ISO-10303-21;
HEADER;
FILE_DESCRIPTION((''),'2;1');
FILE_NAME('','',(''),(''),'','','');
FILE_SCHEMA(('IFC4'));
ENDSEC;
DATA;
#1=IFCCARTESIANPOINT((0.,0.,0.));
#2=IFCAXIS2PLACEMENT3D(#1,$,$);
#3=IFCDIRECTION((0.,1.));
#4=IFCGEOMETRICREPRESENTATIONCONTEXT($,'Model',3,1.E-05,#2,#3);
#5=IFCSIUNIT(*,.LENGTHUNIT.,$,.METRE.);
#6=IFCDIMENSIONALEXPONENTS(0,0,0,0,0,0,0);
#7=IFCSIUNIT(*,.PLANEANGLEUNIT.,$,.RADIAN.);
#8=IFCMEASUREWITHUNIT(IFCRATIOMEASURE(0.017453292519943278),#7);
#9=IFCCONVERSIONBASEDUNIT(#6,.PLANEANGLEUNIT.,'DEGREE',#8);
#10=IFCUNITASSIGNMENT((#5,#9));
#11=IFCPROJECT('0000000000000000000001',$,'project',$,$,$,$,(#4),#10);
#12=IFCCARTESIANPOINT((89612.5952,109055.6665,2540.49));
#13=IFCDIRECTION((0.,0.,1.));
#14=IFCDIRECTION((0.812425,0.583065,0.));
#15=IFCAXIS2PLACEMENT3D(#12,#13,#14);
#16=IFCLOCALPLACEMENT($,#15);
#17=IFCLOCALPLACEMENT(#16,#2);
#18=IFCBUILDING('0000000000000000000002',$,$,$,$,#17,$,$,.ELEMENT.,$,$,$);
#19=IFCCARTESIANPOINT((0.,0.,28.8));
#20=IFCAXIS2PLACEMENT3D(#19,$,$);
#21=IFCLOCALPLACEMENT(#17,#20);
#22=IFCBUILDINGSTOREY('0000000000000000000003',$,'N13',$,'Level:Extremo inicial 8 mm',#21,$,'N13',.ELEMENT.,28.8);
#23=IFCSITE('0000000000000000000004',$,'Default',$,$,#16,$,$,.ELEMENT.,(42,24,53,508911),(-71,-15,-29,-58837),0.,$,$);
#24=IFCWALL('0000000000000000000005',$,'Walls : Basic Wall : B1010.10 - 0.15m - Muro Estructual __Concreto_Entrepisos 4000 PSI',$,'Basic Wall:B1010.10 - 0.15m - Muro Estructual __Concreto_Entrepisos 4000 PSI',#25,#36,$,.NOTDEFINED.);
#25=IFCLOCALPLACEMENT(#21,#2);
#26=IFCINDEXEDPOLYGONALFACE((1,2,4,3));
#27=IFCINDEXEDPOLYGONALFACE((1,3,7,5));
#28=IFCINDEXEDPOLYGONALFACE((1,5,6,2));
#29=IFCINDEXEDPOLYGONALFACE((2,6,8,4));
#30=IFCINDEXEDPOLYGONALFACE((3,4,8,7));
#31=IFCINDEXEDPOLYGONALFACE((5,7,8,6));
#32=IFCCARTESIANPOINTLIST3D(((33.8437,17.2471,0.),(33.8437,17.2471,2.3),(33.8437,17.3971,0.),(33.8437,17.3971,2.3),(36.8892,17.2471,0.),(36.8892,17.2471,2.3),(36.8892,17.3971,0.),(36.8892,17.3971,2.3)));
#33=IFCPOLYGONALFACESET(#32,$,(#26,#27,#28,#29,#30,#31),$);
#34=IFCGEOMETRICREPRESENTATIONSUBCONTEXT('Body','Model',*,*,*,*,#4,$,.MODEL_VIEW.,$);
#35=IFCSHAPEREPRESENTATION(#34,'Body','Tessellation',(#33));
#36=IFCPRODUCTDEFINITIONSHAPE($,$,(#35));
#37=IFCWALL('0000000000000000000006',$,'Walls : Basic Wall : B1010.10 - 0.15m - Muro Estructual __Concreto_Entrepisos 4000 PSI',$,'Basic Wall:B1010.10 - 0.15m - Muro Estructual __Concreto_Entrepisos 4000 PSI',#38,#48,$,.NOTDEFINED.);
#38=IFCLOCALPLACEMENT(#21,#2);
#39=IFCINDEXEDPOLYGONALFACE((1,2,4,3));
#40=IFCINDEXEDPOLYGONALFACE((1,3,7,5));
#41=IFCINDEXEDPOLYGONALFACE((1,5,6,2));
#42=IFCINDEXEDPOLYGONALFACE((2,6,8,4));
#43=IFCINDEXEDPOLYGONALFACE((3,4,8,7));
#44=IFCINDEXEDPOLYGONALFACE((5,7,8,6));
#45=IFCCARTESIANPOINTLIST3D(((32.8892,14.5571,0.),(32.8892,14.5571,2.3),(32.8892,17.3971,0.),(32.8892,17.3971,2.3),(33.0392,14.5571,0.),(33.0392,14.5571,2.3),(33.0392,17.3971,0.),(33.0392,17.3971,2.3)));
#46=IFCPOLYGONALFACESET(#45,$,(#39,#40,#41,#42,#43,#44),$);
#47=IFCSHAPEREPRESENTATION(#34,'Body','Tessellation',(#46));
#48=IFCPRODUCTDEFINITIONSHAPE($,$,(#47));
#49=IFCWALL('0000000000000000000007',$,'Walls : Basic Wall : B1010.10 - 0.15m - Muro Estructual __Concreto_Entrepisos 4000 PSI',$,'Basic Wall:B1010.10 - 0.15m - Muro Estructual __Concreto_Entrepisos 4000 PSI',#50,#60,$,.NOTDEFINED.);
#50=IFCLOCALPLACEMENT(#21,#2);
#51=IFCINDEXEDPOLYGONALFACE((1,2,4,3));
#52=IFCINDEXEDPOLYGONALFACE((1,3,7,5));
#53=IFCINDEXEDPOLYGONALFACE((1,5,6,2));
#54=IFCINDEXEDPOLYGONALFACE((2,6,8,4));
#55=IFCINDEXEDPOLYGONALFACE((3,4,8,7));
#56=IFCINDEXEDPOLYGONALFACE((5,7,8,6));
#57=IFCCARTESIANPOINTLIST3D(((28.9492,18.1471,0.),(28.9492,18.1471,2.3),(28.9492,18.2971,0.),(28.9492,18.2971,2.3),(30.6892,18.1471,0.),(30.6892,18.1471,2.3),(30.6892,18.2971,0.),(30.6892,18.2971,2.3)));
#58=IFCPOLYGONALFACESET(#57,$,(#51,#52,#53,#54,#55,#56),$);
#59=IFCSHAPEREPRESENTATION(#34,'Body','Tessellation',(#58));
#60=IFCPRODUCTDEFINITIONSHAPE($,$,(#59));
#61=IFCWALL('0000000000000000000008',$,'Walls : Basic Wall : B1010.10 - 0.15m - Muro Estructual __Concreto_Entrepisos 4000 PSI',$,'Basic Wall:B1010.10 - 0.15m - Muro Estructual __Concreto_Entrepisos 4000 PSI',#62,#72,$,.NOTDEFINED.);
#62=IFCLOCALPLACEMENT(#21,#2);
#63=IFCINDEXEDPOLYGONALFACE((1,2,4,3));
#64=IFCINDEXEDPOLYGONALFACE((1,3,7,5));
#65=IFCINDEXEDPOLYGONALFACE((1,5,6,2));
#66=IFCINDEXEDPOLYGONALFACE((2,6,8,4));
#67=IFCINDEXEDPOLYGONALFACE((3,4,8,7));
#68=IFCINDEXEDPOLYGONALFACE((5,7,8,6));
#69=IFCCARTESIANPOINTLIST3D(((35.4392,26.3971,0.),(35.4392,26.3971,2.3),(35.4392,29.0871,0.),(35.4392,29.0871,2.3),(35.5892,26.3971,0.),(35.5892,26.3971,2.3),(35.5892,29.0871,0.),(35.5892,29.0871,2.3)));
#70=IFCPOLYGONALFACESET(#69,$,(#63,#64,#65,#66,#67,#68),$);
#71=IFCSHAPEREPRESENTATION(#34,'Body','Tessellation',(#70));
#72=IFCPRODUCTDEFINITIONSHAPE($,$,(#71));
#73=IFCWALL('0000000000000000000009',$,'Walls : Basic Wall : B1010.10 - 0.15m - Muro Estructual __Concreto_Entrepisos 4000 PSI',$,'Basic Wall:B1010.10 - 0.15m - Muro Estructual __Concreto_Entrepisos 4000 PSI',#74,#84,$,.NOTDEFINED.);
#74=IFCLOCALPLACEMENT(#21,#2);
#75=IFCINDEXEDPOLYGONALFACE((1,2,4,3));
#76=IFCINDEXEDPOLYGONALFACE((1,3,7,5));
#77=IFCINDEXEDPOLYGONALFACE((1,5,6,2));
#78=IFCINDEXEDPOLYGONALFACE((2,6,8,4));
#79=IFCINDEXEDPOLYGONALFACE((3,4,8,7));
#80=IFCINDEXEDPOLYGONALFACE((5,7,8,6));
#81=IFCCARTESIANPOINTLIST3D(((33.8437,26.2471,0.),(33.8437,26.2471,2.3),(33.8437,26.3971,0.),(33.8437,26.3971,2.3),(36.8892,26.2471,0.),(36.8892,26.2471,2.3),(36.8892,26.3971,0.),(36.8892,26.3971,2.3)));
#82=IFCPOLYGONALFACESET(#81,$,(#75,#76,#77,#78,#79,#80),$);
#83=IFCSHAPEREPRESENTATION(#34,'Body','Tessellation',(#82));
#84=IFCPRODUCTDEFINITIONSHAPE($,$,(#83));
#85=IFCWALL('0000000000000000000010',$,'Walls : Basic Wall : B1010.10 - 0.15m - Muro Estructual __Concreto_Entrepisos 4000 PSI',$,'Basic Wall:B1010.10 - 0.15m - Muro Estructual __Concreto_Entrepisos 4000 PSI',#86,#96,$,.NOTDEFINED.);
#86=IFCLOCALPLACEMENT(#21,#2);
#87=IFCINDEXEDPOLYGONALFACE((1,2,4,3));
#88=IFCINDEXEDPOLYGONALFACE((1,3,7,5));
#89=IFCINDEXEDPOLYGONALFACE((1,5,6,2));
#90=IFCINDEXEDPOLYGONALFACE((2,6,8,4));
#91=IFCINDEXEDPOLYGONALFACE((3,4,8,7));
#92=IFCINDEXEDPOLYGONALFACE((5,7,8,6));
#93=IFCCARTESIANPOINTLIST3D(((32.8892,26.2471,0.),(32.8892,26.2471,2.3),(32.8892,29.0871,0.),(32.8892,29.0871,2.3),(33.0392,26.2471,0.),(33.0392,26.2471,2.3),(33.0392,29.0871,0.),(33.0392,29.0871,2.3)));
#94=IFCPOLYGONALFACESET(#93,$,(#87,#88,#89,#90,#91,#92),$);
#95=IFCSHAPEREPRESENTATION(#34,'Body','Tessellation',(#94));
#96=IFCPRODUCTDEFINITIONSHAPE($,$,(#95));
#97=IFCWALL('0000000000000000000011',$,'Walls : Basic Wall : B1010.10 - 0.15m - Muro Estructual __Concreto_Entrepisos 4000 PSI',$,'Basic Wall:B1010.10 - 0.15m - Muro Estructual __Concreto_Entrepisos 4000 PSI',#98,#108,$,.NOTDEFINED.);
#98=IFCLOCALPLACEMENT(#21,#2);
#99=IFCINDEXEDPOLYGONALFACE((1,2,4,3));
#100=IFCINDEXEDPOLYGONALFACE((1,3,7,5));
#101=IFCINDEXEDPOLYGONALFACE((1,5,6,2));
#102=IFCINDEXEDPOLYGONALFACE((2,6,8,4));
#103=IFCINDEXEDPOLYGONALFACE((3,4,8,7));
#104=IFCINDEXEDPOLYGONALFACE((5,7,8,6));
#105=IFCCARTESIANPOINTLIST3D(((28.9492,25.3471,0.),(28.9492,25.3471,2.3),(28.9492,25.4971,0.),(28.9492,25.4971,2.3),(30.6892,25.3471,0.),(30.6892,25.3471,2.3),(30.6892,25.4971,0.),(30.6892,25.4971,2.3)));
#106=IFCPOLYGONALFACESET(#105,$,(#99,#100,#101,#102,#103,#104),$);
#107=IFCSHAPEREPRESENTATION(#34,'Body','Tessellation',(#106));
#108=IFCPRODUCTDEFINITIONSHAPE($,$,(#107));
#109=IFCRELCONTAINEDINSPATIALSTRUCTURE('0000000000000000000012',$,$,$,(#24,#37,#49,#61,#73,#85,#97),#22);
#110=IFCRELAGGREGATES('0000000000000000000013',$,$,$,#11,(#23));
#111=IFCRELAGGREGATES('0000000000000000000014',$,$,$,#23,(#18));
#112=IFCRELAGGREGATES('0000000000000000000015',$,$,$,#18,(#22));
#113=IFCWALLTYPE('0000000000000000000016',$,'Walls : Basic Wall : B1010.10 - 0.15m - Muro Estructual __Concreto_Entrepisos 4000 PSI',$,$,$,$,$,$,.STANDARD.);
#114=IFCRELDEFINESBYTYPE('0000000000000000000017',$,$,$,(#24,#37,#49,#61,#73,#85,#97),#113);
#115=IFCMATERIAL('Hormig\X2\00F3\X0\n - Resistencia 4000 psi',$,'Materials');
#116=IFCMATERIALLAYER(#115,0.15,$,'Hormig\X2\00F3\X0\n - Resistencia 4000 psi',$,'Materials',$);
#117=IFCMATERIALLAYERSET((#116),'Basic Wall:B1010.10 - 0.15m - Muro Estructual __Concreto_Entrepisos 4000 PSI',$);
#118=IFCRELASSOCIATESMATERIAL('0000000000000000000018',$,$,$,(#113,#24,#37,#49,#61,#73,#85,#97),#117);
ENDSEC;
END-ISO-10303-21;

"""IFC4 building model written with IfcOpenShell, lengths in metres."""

from ifc_helpers import new_model, entity, si_unit, converted_unit, direction, frame, frame_2d, origin, place, context, subcontext, project, spatial, rectangle, extrude, material, layer, layer_set, layer_usage, type_object, element, save


model = new_model("IFC4")

# Units and contexts
model_context = context("Model", 3, precision=1e-05, world=origin(), true_north=direction((0.0, 1.0)))
body_context = subcontext(model_context, "Body", "Model", "MODEL_VIEW")
ifc_project = project(units=[si_unit("LENGTHUNIT", "METRE"), converted_unit("PLANEANGLEUNIT", "DEGREE", entity("IfcRatioMeasure", 0.017453292519943278), si_unit("PLANEANGLEUNIT", "RADIAN"), dimensions=[0, 0, 0, 0, 0, 0, 0])], contexts=[model_context])

# Site, building, storey
site_placement = place(None, frame((89612.5952, 109055.6665, 2540.49), z_axis=(0.0, 0.0, 1.0), x_axis=(0.812425, 0.583065, 0.0)))
site = spatial("IfcSite", under=ifc_project, at=site_placement, Name="Default", CompositionType="ELEMENT", RefLatitude=(42, 24, 53, 508911), RefLongitude=(-71, -15, -29, -58837), RefElevation=0.0)
building_placement = place(site_placement, origin())
building = spatial("IfcBuilding", under=site, at=building_placement, CompositionType="ELEMENT")
storey_placement = place(building_placement, frame((0.0, 0.0, 28.8)))
storey = spatial("IfcBuildingStorey", under=building, at=storey_placement, Name="N13", ObjectType="Level:Extremo inicial 8 mm", LongName="N13", CompositionType="ELEMENT", Elevation=28.8)

# Walls
ifc_material = material(Name="Hormigón - Resistencia 4000 psi", Category="Materials")
ifc_layer_1 = layer(ifc_material, 0.15, Name="Hormigón - Resistencia 4000 psi", Category="Materials")
ifc_layer_set_1 = layer_set([ifc_layer_1], Name="Basic Wall:B1010.10 - 0.15m - Muro Estructual __Concreto_Entrepisos 4000 PSI")
wall_type_1 = type_object("IfcWallType", Name="Walls : Basic Wall : B1010.10 - 0.15m - Muro Estructual __Concreto_Entrepisos 4000 PSI", PredefinedType="STANDARD", material=ifc_layer_set_1)
ifc_layer_usage_1 = layer_usage(ifc_layer_set_1, "AXIS2", "NEGATIVE", 0.075)
wall_1_placement = place(storey_placement, frame((36.8892, 17.3221, 0.0), z_axis=(0.0, 0.0, 1.0), x_axis=(-1.0, 0.0, 0.0)))
element("IfcWall", 1, at=wall_1_placement, inside=storey, type_object=wall_type_1, material=ifc_layer_usage_1, Name="Walls : Basic Wall : B1010.10 - 0.15m - Muro Estructual __Concreto_Entrepisos 4000 PSI", ObjectType="Basic Wall:B1010.10 - 0.15m - Muro Estructual __Concreto_Entrepisos 4000 PSI", PredefinedType="NOTDEFINED", context=body_context, shape_type="SweptSolid", body=[
    extrude(rectangle(XDim=3.0455, YDim=0.15, at=frame_2d((1.5228, 0.0), x_axis=(-1.0, 0.0))), origin(), (0.0, 0.0, 1.0), 2.3),
])
ifc_layer_usage_2 = layer_usage(ifc_layer_set_1, "AXIS2", "NEGATIVE", 0.075)
wall_2_placement = place(storey_placement, frame((32.9642, 14.5571, 0.0), z_axis=(0.0, 0.0, 1.0), x_axis=(0.0, 1.0, 0.0)))
element("IfcWall", 2, at=wall_2_placement, inside=storey, type_object=wall_type_1, material=ifc_layer_usage_2, Name="Walls : Basic Wall : B1010.10 - 0.15m - Muro Estructual __Concreto_Entrepisos 4000 PSI", ObjectType="Basic Wall:B1010.10 - 0.15m - Muro Estructual __Concreto_Entrepisos 4000 PSI", PredefinedType="NOTDEFINED", context=body_context, shape_type="SweptSolid", body=[
    extrude(rectangle(XDim=2.84, YDim=0.15, at=frame_2d((1.42, 0.0), x_axis=(-1.0, 0.0))), origin(), (0.0, 0.0, 1.0), 2.3),
])
ifc_layer_usage_3 = layer_usage(ifc_layer_set_1, "AXIS2", "NEGATIVE", 0.075)
wall_3_placement = place(storey_placement, frame((30.6892, 18.2221, 0.0), z_axis=(0.0, 0.0, 1.0), x_axis=(-1.0, 0.0, 0.0)))
element("IfcWall", 3, at=wall_3_placement, inside=storey, type_object=wall_type_1, material=ifc_layer_usage_3, Name="Walls : Basic Wall : B1010.10 - 0.15m - Muro Estructual __Concreto_Entrepisos 4000 PSI", ObjectType="Basic Wall:B1010.10 - 0.15m - Muro Estructual __Concreto_Entrepisos 4000 PSI", PredefinedType="NOTDEFINED", context=body_context, shape_type="SweptSolid", body=[
    extrude(rectangle(XDim=1.74, YDim=0.15, at=frame_2d((0.87, 0.0), x_axis=(-1.0, 0.0))), origin(), (0.0, 0.0, 1.0), 2.3),
])
ifc_layer_usage_4 = layer_usage(ifc_layer_set_1, "AXIS2", "POSITIVE", -0.075)
wall_4_placement = place(storey_placement, frame((35.5142, 29.0871, 0.0), z_axis=(0.0, 0.0, 1.0), x_axis=(0.0, -1.0, 0.0)))
element("IfcWall", 4, at=wall_4_placement, inside=storey, type_object=wall_type_1, material=ifc_layer_usage_4, Name="Walls : Basic Wall : B1010.10 - 0.15m - Muro Estructual __Concreto_Entrepisos 4000 PSI", ObjectType="Basic Wall:B1010.10 - 0.15m - Muro Estructual __Concreto_Entrepisos 4000 PSI", PredefinedType="NOTDEFINED", context=body_context, shape_type="SweptSolid", body=[
    extrude(rectangle(XDim=2.69, YDim=0.15, at=frame_2d((1.345, 0.0), x_axis=(-1.0, 0.0))), origin(), (0.0, 0.0, 1.0), 2.3),
])
ifc_layer_usage_5 = layer_usage(ifc_layer_set_1, "AXIS2", "POSITIVE", -0.075)
wall_5_placement = place(storey_placement, frame((36.8892, 26.3221, 0.0), z_axis=(0.0, 0.0, 1.0), x_axis=(-1.0, 0.0, 0.0)))
element("IfcWall", 5, at=wall_5_placement, inside=storey, type_object=wall_type_1, material=ifc_layer_usage_5, Name="Walls : Basic Wall : B1010.10 - 0.15m - Muro Estructual __Concreto_Entrepisos 4000 PSI", ObjectType="Basic Wall:B1010.10 - 0.15m - Muro Estructual __Concreto_Entrepisos 4000 PSI", PredefinedType="NOTDEFINED", context=body_context, shape_type="SweptSolid", body=[
    extrude(rectangle(XDim=3.0455, YDim=0.15, at=frame_2d((1.5228, 0.0), x_axis=(-1.0, 0.0))), origin(), (0.0, 0.0, 1.0), 2.3),
])
ifc_layer_usage_6 = layer_usage(ifc_layer_set_1, "AXIS2", "POSITIVE", -0.075)
wall_6_placement = place(storey_placement, frame((32.9642, 29.0871, 0.0), z_axis=(0.0, 0.0, 1.0), x_axis=(0.0, -1.0, 0.0)))
element("IfcWall", 6, at=wall_6_placement, inside=storey, type_object=wall_type_1, material=ifc_layer_usage_6, Name="Walls : Basic Wall : B1010.10 - 0.15m - Muro Estructual __Concreto_Entrepisos 4000 PSI", ObjectType="Basic Wall:B1010.10 - 0.15m - Muro Estructual __Concreto_Entrepisos 4000 PSI", PredefinedType="NOTDEFINED", context=body_context, shape_type="SweptSolid", body=[
    extrude(rectangle(XDim=2.84, YDim=0.15, at=frame_2d((1.42, 0.0), x_axis=(-1.0, 0.0))), origin(), (0.0, 0.0, 1.0), 2.3),
])
ifc_layer_usage_7 = layer_usage(ifc_layer_set_1, "AXIS2", "POSITIVE", -0.075)
wall_7_placement = place(storey_placement, frame((30.6892, 25.4221, 0.0), z_axis=(0.0, 0.0, 1.0), x_axis=(-1.0, 0.0, 0.0)))
element("IfcWall", 7, at=wall_7_placement, inside=storey, type_object=wall_type_1, material=ifc_layer_usage_7, Name="Walls : Basic Wall : B1010.10 - 0.15m - Muro Estructual __Concreto_Entrepisos 4000 PSI", ObjectType="Basic Wall:B1010.10 - 0.15m - Muro Estructual __Concreto_Entrepisos 4000 PSI", PredefinedType="NOTDEFINED", context=body_context, shape_type="SweptSolid", body=[
    extrude(rectangle(XDim=1.74, YDim=0.15, at=frame_2d((0.87, 0.0), x_axis=(-1.0, 0.0))), origin(), (0.0, 0.0, 1.0), 2.3),
])

save(model, "model.ifc")
